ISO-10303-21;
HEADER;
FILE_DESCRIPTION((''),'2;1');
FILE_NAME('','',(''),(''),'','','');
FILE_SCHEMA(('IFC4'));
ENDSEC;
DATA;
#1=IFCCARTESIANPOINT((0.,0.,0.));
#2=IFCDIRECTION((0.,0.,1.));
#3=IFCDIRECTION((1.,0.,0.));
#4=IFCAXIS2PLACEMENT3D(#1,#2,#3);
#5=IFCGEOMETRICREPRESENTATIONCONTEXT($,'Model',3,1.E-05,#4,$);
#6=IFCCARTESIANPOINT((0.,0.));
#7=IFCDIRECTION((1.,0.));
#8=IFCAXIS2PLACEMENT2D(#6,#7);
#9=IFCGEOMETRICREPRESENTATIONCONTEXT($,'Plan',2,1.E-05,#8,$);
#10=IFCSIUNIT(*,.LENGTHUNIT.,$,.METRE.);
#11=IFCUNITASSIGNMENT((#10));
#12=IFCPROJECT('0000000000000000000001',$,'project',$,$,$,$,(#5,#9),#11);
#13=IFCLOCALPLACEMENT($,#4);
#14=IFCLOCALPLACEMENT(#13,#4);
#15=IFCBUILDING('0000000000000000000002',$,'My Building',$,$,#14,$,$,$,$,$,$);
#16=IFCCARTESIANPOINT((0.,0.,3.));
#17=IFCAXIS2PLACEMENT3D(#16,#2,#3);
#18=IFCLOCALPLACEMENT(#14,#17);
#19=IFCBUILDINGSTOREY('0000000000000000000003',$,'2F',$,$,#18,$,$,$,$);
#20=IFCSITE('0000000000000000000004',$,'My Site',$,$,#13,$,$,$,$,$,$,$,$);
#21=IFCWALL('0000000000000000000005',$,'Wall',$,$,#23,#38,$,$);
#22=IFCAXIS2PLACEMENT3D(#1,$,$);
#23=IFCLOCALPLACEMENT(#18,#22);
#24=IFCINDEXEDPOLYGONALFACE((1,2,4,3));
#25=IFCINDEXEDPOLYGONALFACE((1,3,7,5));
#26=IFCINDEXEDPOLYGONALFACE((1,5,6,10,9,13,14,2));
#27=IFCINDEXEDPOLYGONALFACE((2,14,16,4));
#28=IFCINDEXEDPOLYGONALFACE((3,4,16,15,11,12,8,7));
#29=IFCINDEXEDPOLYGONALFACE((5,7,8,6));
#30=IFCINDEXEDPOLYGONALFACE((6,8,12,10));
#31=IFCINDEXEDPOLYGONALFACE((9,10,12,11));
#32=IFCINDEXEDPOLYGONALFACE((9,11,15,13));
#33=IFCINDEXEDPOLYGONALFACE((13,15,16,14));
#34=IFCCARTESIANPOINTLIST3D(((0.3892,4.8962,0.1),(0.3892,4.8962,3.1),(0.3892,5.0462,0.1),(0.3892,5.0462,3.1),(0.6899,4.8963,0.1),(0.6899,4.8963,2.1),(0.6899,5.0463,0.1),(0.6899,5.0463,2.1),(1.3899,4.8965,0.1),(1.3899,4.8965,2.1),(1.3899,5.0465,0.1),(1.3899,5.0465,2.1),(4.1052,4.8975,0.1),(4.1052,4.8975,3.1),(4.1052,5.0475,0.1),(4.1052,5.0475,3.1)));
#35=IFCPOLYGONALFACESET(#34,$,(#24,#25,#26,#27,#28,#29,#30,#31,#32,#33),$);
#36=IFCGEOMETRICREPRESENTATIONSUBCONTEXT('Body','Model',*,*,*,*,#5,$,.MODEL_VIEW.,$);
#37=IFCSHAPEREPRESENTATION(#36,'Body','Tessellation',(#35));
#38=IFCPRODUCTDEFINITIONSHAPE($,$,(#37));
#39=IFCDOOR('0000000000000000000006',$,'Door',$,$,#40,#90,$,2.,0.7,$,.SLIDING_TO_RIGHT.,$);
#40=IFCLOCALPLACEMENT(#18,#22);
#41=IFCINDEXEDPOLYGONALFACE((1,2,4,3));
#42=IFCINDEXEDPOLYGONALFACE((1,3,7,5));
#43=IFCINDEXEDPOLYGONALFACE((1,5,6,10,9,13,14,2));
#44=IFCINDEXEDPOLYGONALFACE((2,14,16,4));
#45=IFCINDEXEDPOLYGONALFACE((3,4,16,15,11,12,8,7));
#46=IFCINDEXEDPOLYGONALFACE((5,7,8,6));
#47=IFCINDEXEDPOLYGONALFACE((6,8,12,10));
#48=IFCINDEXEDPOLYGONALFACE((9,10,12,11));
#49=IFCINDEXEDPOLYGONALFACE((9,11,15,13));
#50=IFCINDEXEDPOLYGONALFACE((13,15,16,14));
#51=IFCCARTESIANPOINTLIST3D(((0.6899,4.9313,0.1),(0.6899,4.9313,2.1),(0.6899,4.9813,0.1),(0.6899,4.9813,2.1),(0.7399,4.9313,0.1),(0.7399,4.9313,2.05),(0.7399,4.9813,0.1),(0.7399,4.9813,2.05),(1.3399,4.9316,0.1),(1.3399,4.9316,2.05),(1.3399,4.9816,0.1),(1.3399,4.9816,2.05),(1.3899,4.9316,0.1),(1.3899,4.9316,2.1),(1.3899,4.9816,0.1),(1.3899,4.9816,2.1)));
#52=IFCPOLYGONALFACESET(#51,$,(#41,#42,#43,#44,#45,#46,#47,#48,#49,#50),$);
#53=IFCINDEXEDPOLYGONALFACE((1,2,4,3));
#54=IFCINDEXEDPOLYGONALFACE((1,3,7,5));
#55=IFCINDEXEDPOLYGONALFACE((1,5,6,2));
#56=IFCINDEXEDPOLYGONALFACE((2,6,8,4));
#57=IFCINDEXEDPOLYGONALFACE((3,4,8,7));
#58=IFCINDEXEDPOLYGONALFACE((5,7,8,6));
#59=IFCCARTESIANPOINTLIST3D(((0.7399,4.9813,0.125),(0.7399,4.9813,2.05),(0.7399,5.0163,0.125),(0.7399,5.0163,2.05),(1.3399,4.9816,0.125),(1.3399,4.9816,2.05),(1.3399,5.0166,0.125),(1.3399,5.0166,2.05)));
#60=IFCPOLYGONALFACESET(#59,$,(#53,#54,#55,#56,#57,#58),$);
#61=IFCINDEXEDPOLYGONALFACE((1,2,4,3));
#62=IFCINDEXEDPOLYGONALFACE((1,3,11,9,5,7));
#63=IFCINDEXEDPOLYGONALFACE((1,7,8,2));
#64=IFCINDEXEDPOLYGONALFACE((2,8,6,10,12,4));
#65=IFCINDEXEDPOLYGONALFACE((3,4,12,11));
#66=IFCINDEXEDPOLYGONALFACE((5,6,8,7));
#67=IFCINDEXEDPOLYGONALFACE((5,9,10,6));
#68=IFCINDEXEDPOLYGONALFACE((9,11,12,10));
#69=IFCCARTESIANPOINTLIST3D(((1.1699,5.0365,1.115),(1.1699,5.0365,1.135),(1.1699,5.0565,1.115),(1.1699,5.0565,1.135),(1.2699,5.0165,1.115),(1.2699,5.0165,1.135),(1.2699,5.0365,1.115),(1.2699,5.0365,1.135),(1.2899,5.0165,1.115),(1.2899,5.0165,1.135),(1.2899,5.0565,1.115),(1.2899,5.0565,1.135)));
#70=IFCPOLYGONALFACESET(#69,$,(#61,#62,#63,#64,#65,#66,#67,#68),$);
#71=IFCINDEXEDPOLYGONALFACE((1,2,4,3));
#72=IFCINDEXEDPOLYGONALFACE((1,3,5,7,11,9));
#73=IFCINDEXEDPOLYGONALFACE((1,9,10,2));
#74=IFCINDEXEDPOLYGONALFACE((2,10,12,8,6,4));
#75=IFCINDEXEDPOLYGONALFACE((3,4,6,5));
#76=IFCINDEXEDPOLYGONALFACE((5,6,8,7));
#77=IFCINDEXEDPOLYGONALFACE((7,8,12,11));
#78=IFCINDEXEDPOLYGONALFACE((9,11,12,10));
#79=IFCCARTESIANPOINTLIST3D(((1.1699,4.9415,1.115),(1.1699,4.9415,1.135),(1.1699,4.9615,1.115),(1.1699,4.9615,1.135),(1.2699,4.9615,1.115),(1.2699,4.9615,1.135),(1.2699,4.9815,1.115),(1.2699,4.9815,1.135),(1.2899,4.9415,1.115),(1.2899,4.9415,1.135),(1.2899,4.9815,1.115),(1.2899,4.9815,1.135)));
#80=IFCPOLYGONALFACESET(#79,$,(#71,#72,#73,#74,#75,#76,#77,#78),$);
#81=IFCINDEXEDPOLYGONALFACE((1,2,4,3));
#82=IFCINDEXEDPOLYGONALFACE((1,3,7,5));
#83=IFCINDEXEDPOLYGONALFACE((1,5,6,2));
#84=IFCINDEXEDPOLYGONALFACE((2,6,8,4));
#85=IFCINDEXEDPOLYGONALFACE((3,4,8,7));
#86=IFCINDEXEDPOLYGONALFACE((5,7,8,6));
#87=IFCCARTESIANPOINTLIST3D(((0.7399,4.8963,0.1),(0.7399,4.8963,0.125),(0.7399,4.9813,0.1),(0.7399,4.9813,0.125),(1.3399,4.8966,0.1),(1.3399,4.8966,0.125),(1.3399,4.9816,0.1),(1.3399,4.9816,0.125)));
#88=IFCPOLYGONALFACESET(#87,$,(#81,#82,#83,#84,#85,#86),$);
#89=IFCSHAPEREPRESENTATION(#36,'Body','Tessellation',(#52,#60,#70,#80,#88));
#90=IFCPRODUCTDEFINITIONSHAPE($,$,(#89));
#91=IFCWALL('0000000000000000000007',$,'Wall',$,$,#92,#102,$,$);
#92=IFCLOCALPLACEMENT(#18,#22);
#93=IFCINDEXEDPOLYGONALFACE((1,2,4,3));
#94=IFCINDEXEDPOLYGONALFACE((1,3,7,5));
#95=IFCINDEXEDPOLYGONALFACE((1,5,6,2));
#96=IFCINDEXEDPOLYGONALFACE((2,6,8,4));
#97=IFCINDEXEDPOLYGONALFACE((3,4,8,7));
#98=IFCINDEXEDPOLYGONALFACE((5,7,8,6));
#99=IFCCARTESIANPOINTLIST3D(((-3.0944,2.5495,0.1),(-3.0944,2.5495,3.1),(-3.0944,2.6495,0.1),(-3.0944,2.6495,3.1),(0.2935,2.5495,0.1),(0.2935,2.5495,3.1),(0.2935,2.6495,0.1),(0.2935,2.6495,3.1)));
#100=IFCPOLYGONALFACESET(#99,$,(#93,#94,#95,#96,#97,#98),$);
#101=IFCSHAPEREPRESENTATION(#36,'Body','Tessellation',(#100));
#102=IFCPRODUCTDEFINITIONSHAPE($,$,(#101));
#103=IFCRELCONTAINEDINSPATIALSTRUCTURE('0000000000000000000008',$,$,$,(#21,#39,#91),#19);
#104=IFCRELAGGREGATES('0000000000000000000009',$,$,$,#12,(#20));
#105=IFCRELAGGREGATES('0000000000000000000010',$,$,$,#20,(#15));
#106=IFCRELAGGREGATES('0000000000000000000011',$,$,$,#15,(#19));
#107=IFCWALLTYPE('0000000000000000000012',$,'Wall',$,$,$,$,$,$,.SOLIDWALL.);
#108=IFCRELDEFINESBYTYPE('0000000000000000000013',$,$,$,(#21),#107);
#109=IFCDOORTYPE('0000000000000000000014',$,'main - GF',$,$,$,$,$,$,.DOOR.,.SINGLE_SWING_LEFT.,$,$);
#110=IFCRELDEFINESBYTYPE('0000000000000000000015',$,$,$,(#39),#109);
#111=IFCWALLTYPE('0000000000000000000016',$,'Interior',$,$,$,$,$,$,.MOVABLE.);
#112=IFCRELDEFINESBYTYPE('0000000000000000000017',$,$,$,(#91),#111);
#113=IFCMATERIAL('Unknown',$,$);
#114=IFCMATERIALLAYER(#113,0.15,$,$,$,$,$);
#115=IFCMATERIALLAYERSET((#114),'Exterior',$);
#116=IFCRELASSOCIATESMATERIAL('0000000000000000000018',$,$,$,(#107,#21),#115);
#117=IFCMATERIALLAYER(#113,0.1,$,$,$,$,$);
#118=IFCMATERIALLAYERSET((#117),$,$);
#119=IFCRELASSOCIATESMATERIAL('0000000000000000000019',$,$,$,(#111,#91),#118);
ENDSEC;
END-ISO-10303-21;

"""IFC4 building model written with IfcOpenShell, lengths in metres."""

from ifc_helpers import new_model, entity, si_unit, frame, origin_with_axes, origin_2d_with_axis, place, context, subcontext, project, spatial, line, indexed_curve, outline, extrude, shape, source, transform, mapped, material, layer, layer_set, layer_usage, type_object, type_shapes, element, fill, save


model = new_model("IFC4")

# Units and contexts
model_context = context("Model", 3, precision=1e-05, world=origin_with_axes())
plan_context = context("Plan", 2, precision=1e-05, world=origin_2d_with_axis())
body_context_1 = subcontext(model_context, "Body", "Model", "MODEL_VIEW")
body_context_2 = subcontext(plan_context, "Body", "Plan", "PLAN_VIEW")
ifc_project = project(units=[si_unit("LENGTHUNIT", "METRE")], contexts=[model_context, plan_context])

# Site, building, storey
site_placement = place(None, origin_with_axes())
site = spatial("IfcSite", under=ifc_project, at=site_placement, Name="My Site")
building_placement = place(site_placement, origin_with_axes())
building = spatial("IfcBuilding", under=site, at=building_placement, Name="My Building")
storey_placement = place(building_placement, frame((0.0, 0.0, 3.0), z_axis=(0.0, 0.0, 1.0), x_axis=(1.0, 0.0, 0.0)))
storey = spatial("IfcBuildingStorey", under=building, at=storey_placement, Name="2F")

# Shared definitions
ifc_material = material(Name="Unknown")

# Shared definitions
ifc_layer_1 = layer(ifc_material, 0.15)
ifc_layer_set_1 = layer_set([ifc_layer_1], Name="Exterior")
wall_type_1 = type_object("IfcWallType", Name="Wall", PredefinedType="SOLIDWALL", material=ifc_layer_set_1)

# Wall, opening, door
ifc_layer_usage_1 = layer_usage(ifc_layer_set_1, "AXIS2", "POSITIVE", 0.0)
wall_1_placement = place(storey_placement, frame((0.3892, 4.8962, 0.1), z_axis=(0.0, 0.0, 1.0), x_axis=(1.0, 0.000354, 0.0)))
wall_1 = element("IfcWall", 1, at=wall_1_placement, inside=storey, type_object=wall_type_1, material=ifc_layer_usage_1, Name="Wall", context=body_context_1, shape_type="SweptSolid", body=[
    extrude(outline(indexed_curve([(0.0, 0.0), (0.0, 0.15), (3.716, 0.15), (3.716, 0.0)], segments=[line(1, 2, 3, 4, 1)])), origin_with_axes(), (0.0, 0.0, 1.0), 3.0),
])
shared_shape_1 = source(origin_with_axes(), body_context_1, "Body", "SweptSolid", [
    extrude(outline(indexed_curve([(0.0, 0.0), (0.7, 0.0), (0.7, 2.0), (0.0, 2.0)], segments=[line(1, 2, 3, 4, 1)])), frame((0.0, -0.6, 0.0), z_axis=(0.0, -1.0, 0.0), x_axis=(1.0, 0.0, 0.0)), (0.0, 0.0, -1.0), 1.2),
])
opening_1_placement = place(wall_1_placement, frame((1.0007, 0.085, 0.0), z_axis=(0.0, 0.0, 1.0), x_axis=(-1.0, 0.0, 0.0)))
opening_1 = element("IfcOpeningElement", 2, at=opening_1_placement, cuts=wall_1, PredefinedType="OPENING", context=body_context_1, shape_type="MappedRepresentation", body=[
    mapped(shared_shape_1, transform((0.0, 0.0, 0.0), x_axis=(1.0, 0.0, 0.0), y_axis=(0.0, 1.0, 0.0), z_axis=(0.0, 0.0, 1.0), scale=1.0)),
])
door_type_1 = type_object("IfcDoorType", Name="main - GF", OperationType="SINGLE_SWING_LEFT", PredefinedType="DOOR")
shared_shape_2 = source(origin_with_axes(), body_context_1, "Body", "SweptSolid", [
    extrude(outline(indexed_curve([(0.0, 0.0), (0.0, 2.0), (0.7, 2.0), (0.7, 0.0), (0.65, 0.0), (0.65, 1.95), (0.05, 1.95), (0.05, 0.0)], segments=[line(1, 2, 3, 4, 5, 6, 7, 8, 1)])), frame((0.0, 0.0, 0.0), z_axis=(0.0, -1.0, 0.0), x_axis=(1.0, 0.0, 0.0)), (0.0, 0.0, -1.0), 0.05),
    extrude(outline(indexed_curve([(0.0, 0.0), (0.6, 0.0), (0.6, 0.035), (0.0, 0.035)], segments=[line(1, 2, 3, 4, 1)])), frame((0.05, -0.035, 0.025), z_axis=(0.0, 0.0, 1.0), x_axis=(1.0, 0.0, 0.0)), (0.0, 0.0, 1.0), 1.925),
    extrude(outline(indexed_curve([(0.0, 0.0), (0.0, -0.04), (0.12, -0.04), (0.12, -0.02), (0.02, -0.02), (0.02, 0.0)], segments=[line(1, 2, 3, 4, 5, 6, 1)])), frame((0.1, -0.035, 1.015), z_axis=(0.0, 0.0, 1.0), x_axis=(1.0, 0.0, 0.0)), (0.0, 0.0, 1.0), 0.02),
    extrude(outline(indexed_curve([(0.0, 0.0), (0.0, 0.04), (0.12, 0.04), (0.12, 0.02), (0.02, 0.02), (0.02, 0.0)], segments=[line(1, 2, 3, 4, 5, 6, 1)])), frame((0.1, 0.0, 1.015), z_axis=(0.0, 0.0, 1.0), x_axis=(1.0, 0.0, 0.0)), (0.0, 0.0, 1.0), 0.02),
    extrude(outline(indexed_curve([(0.0, 0.0), (0.6, 0.0), (0.6, 0.085), (0.0, 0.085)], segments=[line(1, 2, 3, 4, 1)])), frame((0.05, 0.0, 0.0), z_axis=(0.0, 0.0, 1.0), x_axis=(1.0, 0.0, 0.0)), (0.0, 0.0, 1.0), 0.025),
])
shared_shape_3 = source(origin_with_axes(), body_context_2, "Body", "Curve2D", [
    entity("IfcIndexedPolyCurve", entity("IfcCartesianPointList2D", [[0.0, 0.0], [0.05, 0.0], [0.05, 0.05], [0.0, 0.05]]), [entity("IfcLineIndex", [1, 2, 3, 4, 1])]),
    entity("IfcIndexedPolyCurve", entity("IfcCartesianPointList2D", [[0.7, 0.0], [0.65, 0.0], [0.65, 0.05], [0.7, 0.05]]), [entity("IfcLineIndex", [1, 2, 3, 4, 1])]),
    entity("IfcIndexedPolyCurve", entity("IfcCartesianPointList2D", [[0.95, -0.035], [0.35, -0.035], [0.35, 0.0], [0.95, 0.0]]), [entity("IfcLineIndex", [1, 2, 3, 4, 1])]),
])
type_shapes(door_type_1, [shared_shape_2, shared_shape_3])
door_1_placement = place(opening_1_placement, frame((0.0, 0.0, 0.0), z_axis=(0.0, 0.0, 1.0), x_axis=(1.0, 0.0, 0.0)))
door_1 = element("IfcDoor", 3, at=door_1_placement, inside=storey, type_object=door_type_1, Name="Door", OperationType="SLIDING_TO_RIGHT", OverallHeight=2.0, OverallWidth=0.7, shapes=[
    shape(body_context_1, "Body", "MappedRepresentation", [mapped(shared_shape_2, transform((0.0, 0.0, 0.0), x_axis=(1.0, 0.0, 0.0), y_axis=(0.0, 1.0, 0.0), z_axis=(0.0, 0.0, 1.0), scale=1.0))]),
    shape(body_context_2, "Body", "MappedRepresentation", [mapped(shared_shape_3, transform((0.0, 0.0, 0.0), x_axis=(1.0, 0.0, 0.0), y_axis=(0.0, 1.0, 0.0), z_axis=(0.0, 0.0, 1.0), scale=1.0))]),
])
fill(opening_1, door_1)

# Shared definitions
ifc_layer_2 = layer(ifc_material, 0.1)
ifc_layer_set_2 = layer_set([ifc_layer_2])
wall_type_2 = type_object("IfcWallType", Name="Interior", PredefinedType="MOVABLE", material=ifc_layer_set_2)

# Wall
ifc_layer_usage_2 = layer_usage(ifc_layer_set_2, "AXIS2", "POSITIVE", 0.0)
wall_2_placement = place(storey_placement, frame((-3.0944, 2.5495, 0.1), z_axis=(0.0, 0.0, 1.0), x_axis=(1.0, 0.000006, 0.0)))
element("IfcWall", 4, at=wall_2_placement, inside=storey, type_object=wall_type_2, material=ifc_layer_usage_2, Name="Wall", context=body_context_1, shape_type="SweptSolid", body=[
    extrude(outline(indexed_curve([(0.0, 0.0), (0.0, 0.1), (3.3879, 0.1), (3.3879, 0.0)], segments=[line(1, 2, 3, 4, 1)])), origin_with_axes(), (0.0, 0.0, 1.0), 3.0),
])

save(model, "model.ifc")
